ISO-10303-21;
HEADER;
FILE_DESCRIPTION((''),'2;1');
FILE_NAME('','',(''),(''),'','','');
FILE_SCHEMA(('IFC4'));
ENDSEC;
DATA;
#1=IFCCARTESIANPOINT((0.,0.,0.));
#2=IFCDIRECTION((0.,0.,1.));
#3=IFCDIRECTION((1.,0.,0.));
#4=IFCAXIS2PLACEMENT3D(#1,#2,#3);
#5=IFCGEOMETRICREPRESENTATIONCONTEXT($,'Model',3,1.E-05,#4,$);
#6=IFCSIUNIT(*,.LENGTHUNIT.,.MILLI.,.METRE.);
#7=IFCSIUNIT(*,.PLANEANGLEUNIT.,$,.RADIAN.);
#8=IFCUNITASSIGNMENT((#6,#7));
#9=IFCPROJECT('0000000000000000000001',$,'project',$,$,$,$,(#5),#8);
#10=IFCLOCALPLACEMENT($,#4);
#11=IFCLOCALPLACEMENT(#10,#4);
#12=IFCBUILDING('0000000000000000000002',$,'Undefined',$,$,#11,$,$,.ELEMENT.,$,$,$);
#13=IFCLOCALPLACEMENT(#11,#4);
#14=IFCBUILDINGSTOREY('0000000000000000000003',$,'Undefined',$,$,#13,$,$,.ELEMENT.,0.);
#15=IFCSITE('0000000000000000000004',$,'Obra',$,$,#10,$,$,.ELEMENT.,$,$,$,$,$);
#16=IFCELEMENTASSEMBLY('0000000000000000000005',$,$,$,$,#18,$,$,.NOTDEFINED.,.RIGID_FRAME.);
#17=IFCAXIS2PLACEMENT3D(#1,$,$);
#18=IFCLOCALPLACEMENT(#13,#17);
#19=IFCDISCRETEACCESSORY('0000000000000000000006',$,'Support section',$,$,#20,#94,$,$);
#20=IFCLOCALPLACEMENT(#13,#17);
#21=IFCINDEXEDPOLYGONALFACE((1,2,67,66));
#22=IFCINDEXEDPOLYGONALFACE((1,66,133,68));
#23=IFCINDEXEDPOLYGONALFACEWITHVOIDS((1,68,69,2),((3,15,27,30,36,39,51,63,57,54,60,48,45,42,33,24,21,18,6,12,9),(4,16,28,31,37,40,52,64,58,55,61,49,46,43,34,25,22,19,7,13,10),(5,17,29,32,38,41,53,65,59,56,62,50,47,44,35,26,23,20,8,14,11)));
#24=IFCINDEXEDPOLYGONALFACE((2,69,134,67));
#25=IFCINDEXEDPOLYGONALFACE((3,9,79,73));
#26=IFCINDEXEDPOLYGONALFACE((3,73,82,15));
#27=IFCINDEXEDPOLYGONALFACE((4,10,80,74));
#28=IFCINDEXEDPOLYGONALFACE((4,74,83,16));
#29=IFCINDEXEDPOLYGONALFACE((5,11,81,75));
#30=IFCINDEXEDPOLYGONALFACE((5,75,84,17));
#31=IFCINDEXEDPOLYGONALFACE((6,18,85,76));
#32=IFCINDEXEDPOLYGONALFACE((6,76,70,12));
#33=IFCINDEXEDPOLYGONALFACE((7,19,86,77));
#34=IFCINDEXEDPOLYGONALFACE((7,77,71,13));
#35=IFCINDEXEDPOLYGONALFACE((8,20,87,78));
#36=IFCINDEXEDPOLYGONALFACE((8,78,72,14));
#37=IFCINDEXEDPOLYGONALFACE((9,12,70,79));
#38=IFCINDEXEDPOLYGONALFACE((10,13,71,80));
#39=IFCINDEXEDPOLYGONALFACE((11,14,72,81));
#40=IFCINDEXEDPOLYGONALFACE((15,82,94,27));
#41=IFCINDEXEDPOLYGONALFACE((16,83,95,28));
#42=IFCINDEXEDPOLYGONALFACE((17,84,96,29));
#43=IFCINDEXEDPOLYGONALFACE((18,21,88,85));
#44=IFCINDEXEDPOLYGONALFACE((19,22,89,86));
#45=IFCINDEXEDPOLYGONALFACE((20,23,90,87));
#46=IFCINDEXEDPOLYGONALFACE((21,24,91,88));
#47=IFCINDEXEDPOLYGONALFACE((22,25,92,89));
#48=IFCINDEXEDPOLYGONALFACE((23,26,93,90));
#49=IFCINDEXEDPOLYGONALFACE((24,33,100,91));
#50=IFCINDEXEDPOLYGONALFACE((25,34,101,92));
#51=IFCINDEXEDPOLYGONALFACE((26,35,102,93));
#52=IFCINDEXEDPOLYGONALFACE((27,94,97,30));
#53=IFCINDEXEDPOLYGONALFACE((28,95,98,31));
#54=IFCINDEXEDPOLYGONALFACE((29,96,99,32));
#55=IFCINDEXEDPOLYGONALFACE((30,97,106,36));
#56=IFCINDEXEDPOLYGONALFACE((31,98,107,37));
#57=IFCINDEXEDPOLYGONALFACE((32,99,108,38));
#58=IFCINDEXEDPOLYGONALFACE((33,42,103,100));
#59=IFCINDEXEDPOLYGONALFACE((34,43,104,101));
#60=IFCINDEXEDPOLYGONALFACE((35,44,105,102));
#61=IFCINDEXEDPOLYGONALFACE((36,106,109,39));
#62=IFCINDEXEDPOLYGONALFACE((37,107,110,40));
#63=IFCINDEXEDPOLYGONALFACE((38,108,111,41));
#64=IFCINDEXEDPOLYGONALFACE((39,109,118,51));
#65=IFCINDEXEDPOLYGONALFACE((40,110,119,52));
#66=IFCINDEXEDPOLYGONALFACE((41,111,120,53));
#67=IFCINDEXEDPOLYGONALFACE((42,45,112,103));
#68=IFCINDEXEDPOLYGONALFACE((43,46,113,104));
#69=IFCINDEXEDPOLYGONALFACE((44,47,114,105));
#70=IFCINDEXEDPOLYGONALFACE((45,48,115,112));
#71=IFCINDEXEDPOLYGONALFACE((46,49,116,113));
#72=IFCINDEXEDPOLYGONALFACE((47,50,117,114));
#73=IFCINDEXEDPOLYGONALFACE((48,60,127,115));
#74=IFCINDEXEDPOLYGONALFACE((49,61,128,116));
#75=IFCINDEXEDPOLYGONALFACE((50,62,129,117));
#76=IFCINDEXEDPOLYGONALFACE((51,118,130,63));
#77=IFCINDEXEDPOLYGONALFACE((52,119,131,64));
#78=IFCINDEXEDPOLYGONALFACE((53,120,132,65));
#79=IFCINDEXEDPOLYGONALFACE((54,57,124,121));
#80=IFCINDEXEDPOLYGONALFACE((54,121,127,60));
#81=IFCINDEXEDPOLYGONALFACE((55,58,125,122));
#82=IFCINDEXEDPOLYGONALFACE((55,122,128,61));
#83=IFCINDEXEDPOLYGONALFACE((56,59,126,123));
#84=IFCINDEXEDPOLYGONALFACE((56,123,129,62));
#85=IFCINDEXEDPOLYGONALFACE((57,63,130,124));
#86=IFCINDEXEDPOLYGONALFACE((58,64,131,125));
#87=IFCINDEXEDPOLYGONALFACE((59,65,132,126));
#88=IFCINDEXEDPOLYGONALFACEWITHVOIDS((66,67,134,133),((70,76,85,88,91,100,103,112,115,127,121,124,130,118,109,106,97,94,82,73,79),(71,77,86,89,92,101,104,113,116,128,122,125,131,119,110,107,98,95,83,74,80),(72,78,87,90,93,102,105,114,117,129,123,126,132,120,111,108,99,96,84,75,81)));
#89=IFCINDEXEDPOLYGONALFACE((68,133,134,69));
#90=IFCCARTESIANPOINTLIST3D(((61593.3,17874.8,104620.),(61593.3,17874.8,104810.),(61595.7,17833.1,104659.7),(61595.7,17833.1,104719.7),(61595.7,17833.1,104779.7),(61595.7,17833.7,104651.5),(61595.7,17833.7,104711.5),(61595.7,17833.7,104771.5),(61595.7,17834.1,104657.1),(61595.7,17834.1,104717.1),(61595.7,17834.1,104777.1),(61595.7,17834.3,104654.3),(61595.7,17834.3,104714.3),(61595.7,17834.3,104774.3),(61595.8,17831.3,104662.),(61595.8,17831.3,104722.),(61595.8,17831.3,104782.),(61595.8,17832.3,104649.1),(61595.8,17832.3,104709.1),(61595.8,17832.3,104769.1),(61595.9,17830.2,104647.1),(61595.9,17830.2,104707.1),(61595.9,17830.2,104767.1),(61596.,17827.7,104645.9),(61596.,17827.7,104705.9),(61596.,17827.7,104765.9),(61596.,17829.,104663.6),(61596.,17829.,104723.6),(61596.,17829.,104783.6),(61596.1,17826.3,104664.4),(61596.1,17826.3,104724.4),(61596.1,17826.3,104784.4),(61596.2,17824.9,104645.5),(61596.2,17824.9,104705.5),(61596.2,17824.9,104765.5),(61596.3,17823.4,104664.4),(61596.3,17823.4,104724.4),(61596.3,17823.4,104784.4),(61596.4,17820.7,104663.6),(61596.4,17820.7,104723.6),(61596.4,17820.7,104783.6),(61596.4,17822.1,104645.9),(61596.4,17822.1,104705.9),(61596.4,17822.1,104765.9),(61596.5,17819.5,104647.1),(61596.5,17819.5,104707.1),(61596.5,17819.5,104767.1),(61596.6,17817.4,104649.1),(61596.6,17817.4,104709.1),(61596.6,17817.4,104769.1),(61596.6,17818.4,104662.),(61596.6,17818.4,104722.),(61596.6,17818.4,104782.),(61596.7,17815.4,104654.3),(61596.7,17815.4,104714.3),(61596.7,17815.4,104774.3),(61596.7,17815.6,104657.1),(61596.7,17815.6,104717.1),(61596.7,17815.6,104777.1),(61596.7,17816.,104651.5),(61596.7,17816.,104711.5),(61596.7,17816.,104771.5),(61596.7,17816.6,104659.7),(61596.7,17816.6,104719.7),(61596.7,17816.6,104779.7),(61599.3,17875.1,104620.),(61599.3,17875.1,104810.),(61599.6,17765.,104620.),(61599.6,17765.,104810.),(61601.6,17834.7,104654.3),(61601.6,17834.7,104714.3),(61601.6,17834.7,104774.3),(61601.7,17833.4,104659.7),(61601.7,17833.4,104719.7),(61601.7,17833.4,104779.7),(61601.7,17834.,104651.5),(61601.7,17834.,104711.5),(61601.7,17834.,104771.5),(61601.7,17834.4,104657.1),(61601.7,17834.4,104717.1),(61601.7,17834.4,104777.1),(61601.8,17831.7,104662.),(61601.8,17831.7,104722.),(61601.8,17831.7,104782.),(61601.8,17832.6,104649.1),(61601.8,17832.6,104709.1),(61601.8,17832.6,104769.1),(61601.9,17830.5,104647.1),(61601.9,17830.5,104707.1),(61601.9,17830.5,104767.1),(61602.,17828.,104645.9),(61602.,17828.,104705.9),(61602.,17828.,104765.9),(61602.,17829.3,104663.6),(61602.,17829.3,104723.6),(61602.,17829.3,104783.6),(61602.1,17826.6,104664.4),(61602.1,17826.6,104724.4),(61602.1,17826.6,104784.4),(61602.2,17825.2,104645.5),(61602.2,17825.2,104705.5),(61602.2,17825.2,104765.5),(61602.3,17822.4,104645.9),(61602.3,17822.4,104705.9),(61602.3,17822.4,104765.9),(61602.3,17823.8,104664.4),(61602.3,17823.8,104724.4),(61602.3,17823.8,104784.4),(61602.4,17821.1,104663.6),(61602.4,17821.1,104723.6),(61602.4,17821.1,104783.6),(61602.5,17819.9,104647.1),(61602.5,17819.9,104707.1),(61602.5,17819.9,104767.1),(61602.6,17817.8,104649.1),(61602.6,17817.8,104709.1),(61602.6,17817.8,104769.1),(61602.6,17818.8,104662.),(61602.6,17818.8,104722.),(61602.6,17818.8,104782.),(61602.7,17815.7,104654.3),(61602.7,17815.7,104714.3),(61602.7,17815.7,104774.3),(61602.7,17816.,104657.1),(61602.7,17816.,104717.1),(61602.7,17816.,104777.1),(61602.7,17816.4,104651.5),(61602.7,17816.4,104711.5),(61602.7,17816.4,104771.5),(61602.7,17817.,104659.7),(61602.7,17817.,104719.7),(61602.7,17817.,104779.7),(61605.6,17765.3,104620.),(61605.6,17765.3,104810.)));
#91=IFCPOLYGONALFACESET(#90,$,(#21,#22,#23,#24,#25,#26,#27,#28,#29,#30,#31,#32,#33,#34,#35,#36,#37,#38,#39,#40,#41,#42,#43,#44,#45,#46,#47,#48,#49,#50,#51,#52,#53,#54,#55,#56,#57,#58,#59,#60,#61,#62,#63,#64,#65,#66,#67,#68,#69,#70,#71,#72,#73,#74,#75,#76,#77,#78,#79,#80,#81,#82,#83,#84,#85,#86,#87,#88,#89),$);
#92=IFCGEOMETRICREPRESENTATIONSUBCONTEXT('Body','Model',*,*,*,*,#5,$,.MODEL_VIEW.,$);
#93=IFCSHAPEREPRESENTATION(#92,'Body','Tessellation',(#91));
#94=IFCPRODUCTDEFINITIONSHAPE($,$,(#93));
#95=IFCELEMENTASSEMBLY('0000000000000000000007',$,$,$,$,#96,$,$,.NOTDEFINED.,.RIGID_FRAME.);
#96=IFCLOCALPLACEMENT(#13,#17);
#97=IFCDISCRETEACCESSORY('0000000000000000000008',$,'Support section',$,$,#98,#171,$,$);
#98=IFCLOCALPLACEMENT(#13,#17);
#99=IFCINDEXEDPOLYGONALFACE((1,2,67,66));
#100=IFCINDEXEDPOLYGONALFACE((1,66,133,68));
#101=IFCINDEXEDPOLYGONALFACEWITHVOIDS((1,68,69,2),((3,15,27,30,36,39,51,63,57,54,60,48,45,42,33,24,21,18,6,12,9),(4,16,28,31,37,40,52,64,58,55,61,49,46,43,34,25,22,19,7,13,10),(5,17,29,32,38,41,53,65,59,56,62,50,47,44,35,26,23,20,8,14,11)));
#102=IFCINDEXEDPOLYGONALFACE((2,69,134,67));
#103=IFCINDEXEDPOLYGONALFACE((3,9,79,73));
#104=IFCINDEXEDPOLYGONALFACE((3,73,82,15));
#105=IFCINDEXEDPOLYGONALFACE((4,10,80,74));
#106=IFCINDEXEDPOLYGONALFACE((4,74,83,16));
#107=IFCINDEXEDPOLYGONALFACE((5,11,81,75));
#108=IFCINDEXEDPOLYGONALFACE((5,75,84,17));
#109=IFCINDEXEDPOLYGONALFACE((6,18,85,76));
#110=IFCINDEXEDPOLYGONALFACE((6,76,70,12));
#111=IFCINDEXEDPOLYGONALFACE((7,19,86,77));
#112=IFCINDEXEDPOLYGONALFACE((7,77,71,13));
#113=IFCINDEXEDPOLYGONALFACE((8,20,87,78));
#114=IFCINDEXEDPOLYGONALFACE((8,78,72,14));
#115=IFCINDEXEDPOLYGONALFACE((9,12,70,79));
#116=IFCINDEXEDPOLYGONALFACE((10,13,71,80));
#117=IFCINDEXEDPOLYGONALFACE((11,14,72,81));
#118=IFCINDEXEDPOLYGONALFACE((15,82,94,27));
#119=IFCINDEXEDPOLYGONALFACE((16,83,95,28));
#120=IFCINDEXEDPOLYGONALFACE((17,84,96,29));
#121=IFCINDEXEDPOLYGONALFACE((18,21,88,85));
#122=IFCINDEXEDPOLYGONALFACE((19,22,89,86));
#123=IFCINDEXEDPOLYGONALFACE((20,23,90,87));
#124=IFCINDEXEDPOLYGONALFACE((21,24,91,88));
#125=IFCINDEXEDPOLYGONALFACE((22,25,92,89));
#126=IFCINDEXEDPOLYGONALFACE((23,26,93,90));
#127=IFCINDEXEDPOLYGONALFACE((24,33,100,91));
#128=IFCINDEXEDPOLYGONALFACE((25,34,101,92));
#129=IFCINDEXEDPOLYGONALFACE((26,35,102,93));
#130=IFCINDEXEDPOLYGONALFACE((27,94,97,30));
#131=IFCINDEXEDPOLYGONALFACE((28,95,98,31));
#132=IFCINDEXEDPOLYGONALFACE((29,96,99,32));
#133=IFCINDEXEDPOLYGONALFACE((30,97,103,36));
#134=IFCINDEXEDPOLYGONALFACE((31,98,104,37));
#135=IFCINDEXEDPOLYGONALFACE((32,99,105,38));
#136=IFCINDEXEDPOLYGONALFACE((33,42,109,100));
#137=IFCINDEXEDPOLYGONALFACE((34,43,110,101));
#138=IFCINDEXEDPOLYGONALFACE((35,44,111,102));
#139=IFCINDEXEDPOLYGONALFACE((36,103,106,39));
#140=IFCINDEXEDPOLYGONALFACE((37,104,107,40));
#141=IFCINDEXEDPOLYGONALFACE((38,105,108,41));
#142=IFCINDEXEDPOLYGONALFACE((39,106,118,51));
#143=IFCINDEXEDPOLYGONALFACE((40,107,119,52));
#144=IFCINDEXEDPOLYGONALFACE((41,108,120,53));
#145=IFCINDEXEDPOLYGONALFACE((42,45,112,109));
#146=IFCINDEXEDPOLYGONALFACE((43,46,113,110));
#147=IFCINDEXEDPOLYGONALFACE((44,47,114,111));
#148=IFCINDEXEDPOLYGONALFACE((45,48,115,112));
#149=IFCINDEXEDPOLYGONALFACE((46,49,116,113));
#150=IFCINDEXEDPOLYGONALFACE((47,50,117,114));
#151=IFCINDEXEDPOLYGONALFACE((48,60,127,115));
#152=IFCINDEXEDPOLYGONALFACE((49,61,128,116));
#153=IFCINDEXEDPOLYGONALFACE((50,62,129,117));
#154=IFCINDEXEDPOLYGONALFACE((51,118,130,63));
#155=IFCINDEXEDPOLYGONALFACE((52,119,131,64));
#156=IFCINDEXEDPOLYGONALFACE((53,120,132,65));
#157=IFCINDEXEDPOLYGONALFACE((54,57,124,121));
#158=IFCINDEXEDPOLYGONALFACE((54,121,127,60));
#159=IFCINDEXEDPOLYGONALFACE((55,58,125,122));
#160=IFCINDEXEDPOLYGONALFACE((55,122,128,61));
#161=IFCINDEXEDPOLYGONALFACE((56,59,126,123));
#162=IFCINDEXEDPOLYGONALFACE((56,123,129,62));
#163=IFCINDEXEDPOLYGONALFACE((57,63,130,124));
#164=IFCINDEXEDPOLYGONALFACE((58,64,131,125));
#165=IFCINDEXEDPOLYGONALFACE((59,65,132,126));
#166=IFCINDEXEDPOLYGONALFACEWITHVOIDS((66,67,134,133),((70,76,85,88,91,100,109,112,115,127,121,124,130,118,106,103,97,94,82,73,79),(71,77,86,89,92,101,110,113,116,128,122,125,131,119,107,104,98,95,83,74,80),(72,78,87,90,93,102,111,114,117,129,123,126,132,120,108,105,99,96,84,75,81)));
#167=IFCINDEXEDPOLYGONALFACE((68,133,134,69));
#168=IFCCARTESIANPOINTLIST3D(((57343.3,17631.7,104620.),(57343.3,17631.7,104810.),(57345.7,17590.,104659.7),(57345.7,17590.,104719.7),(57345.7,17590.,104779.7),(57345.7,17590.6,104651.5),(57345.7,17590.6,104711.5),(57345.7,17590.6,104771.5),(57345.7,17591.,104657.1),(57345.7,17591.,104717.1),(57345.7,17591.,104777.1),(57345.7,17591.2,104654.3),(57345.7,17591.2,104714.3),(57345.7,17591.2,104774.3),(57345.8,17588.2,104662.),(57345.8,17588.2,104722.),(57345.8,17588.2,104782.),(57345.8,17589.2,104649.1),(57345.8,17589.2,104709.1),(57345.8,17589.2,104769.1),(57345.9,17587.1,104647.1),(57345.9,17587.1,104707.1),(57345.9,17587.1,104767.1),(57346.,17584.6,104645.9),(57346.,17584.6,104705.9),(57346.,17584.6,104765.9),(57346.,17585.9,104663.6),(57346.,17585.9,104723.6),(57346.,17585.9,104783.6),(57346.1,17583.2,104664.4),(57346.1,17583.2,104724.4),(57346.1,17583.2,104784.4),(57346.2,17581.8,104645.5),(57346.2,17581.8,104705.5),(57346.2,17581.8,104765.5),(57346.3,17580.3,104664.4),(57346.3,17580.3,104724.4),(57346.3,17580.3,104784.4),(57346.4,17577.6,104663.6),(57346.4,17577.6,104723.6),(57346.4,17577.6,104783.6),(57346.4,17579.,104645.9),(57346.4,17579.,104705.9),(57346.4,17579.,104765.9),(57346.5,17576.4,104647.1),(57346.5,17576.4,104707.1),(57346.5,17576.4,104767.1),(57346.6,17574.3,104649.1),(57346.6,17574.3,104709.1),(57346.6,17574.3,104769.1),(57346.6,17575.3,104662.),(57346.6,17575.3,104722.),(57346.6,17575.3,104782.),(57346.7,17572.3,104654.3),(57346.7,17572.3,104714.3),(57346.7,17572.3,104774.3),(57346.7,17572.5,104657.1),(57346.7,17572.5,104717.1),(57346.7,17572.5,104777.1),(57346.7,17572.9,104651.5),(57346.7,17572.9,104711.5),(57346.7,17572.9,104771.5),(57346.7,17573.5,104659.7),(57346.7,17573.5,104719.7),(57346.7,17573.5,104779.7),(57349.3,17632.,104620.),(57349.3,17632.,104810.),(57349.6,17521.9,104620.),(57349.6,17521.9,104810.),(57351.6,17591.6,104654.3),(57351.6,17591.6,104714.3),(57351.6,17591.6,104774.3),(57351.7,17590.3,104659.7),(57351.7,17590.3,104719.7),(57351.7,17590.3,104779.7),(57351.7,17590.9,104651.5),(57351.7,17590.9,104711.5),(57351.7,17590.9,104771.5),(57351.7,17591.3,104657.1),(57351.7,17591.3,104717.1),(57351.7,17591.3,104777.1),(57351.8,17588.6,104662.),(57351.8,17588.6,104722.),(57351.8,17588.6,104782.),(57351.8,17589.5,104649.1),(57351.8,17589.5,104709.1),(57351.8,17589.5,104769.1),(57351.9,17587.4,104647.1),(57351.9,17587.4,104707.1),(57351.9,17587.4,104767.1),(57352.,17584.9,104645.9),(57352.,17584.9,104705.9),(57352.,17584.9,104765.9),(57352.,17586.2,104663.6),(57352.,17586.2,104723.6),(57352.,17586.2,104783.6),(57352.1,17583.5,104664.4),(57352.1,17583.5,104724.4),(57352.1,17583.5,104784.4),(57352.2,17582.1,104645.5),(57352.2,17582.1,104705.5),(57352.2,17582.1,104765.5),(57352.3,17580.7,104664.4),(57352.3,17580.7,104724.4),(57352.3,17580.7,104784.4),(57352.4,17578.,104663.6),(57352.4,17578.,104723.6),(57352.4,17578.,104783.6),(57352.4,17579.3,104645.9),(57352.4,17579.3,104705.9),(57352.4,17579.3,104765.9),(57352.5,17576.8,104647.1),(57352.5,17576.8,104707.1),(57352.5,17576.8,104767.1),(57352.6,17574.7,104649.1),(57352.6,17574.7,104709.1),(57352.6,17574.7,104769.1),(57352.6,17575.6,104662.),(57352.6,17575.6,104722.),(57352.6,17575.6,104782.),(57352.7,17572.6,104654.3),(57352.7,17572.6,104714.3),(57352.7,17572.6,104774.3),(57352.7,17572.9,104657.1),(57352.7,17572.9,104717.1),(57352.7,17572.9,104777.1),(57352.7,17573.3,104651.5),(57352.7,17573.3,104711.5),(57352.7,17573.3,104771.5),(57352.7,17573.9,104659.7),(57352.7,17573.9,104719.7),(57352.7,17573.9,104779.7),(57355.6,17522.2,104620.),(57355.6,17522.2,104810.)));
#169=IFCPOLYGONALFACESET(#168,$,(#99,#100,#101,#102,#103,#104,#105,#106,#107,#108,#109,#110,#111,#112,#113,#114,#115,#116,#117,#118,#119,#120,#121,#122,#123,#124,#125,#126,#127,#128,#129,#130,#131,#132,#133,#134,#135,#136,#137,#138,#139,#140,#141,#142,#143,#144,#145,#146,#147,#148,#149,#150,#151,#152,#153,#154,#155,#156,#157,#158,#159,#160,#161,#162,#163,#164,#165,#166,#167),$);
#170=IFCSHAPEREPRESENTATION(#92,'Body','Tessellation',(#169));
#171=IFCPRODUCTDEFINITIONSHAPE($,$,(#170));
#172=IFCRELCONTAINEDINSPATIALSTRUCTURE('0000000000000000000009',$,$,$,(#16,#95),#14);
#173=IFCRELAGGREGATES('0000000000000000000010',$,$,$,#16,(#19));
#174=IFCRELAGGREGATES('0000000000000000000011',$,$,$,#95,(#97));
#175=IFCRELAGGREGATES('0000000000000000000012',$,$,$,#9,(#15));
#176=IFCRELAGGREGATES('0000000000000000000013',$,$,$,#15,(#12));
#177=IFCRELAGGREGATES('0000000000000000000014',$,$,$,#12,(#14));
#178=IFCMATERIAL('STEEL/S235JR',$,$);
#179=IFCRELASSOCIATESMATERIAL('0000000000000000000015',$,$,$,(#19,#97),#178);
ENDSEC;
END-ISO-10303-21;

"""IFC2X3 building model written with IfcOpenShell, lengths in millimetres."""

from ifc_helpers import new_model, si_unit, frame, origin_with_axes, origin_2d_with_axis, place, context, subcontext, project, spatial, rectangle, circle, extrude, source, transform, mapped, material, element, aggregate, save


model = new_model("IFC2X3")

# Units and contexts
model_context = context("Model", 3, precision=1e-05, world=origin_with_axes())
body_context = subcontext(model_context, "Body", "Model", "MODEL_VIEW")
ifc_project = project(units=[si_unit("LENGTHUNIT", "METRE", prefix="MILLI"), si_unit("PLANEANGLEUNIT", "RADIAN")], contexts=[model_context])

# Site, building, storey
site_placement = place(None, origin_with_axes())
site = spatial("IfcSite", under=ifc_project, at=site_placement, Name="Obra", CompositionType="ELEMENT")
building_placement = place(site_placement, origin_with_axes())
building = spatial("IfcBuilding", under=site, at=building_placement, Name="Undefined", CompositionType="ELEMENT")
storey_placement = place(building_placement, origin_with_axes())
storey = spatial("IfcBuildingStorey", under=building, at=storey_placement, Name="Undefined", CompositionType="ELEMENT", Elevation=0.0)

# Shared definitions
ifc_material = material(Name="STEEL/S235JR")

# Element assemblies, discrete accessories, openings
shared_shape_1 = source(origin_with_axes(), body_context, "Body", "SweptSolid", [
    extrude(circle(Radius=9.5, at=origin_2d_with_axis()), frame((0.0, -9.2, 0.0), z_axis=(0.0, 1.0, 0.0), x_axis=(1.0, 0.0, 0.0)), (0.0, 0.0, 1.0), 6.2),
])
assembly_1_placement = place(storey_placement, origin_with_axes())
assembly_1 = element("IfcElementAssembly", 1, at=assembly_1_placement, inside=storey, AssemblyPlace="NOTDEFINED", PredefinedType="RIGID_FRAME")
discrete_accessory_1_placement = place(assembly_1_placement, frame((61599.5, 17820.0, 104620.0), z_axis=(0.0, 0.0, 1.0), x_axis=(0.057107, -0.998368, 0.0)))
discrete_accessory_1 = element("IfcDiscreteAccessory", 2, at=discrete_accessory_1_placement, material=ifc_material, Name="Support section", context=body_context, shape_type="SweptSolid", body=[
    extrude(rectangle(XDim=6.0, YDim=110.0, at=origin_2d_with_axis()), frame((0.0, 0.0, 190.0), z_axis=(0.0, 0.0, -1.0), x_axis=(0.0, 1.0, 0.0)), (0.0, 0.0, 1.0), 190.0),
])
opening_1_placement = place(assembly_1_placement, frame((61596.0, 17774.8, 104835.0), z_axis=(-0.057107, 0.998368, 0.0), x_axis=(0.0, 0.0, -1.0)))
element("IfcOpeningElement", 3, at=opening_1_placement, cuts=discrete_accessory_1, ObjectType="Opening", context=body_context, shape_type="MappedRepresentation", body=[
    mapped(shared_shape_1, transform((60.0, 0.0, 50.0))),
    mapped(shared_shape_1, transform((120.0, 0.0, 50.0))),
    mapped(shared_shape_1, transform((180.0, 0.0, 50.0))),
])
aggregate(assembly_1, [discrete_accessory_1])
assembly_2_placement = place(storey_placement, origin_with_axes())
assembly_2 = element("IfcElementAssembly", 4, at=assembly_2_placement, inside=storey, AssemblyPlace="NOTDEFINED", PredefinedType="RIGID_FRAME")
discrete_accessory_2_placement = place(assembly_2_placement, frame((57349.5, 17576.9, 104620.0), z_axis=(0.0, 0.0, 1.0), x_axis=(0.057107, -0.998368, 0.0)))
discrete_accessory_2 = element("IfcDiscreteAccessory", 5, at=discrete_accessory_2_placement, material=ifc_material, Name="Support section", context=body_context, shape_type="SweptSolid", body=[
    extrude(rectangle(XDim=6.0, YDim=110.0, at=origin_2d_with_axis()), frame((0.0, 0.0, 190.0), z_axis=(0.0, 0.0, -1.0), x_axis=(0.0, 1.0, 0.0)), (0.0, 0.0, 1.0), 190.0),
])
opening_2_placement = place(assembly_2_placement, frame((57346.0, 17531.7, 104835.0), z_axis=(-0.057107, 0.998368, 0.0), x_axis=(0.0, 0.0, -1.0)))
element("IfcOpeningElement", 6, at=opening_2_placement, cuts=discrete_accessory_2, ObjectType="Opening", context=body_context, shape_type="MappedRepresentation", body=[
    mapped(shared_shape_1, transform((60.0, 0.0, 50.0))),
    mapped(shared_shape_1, transform((120.0, 0.0, 50.0))),
    mapped(shared_shape_1, transform((180.0, 0.0, 50.0))),
])
aggregate(assembly_2, [discrete_accessory_2])

save(model, "model.ifc")
